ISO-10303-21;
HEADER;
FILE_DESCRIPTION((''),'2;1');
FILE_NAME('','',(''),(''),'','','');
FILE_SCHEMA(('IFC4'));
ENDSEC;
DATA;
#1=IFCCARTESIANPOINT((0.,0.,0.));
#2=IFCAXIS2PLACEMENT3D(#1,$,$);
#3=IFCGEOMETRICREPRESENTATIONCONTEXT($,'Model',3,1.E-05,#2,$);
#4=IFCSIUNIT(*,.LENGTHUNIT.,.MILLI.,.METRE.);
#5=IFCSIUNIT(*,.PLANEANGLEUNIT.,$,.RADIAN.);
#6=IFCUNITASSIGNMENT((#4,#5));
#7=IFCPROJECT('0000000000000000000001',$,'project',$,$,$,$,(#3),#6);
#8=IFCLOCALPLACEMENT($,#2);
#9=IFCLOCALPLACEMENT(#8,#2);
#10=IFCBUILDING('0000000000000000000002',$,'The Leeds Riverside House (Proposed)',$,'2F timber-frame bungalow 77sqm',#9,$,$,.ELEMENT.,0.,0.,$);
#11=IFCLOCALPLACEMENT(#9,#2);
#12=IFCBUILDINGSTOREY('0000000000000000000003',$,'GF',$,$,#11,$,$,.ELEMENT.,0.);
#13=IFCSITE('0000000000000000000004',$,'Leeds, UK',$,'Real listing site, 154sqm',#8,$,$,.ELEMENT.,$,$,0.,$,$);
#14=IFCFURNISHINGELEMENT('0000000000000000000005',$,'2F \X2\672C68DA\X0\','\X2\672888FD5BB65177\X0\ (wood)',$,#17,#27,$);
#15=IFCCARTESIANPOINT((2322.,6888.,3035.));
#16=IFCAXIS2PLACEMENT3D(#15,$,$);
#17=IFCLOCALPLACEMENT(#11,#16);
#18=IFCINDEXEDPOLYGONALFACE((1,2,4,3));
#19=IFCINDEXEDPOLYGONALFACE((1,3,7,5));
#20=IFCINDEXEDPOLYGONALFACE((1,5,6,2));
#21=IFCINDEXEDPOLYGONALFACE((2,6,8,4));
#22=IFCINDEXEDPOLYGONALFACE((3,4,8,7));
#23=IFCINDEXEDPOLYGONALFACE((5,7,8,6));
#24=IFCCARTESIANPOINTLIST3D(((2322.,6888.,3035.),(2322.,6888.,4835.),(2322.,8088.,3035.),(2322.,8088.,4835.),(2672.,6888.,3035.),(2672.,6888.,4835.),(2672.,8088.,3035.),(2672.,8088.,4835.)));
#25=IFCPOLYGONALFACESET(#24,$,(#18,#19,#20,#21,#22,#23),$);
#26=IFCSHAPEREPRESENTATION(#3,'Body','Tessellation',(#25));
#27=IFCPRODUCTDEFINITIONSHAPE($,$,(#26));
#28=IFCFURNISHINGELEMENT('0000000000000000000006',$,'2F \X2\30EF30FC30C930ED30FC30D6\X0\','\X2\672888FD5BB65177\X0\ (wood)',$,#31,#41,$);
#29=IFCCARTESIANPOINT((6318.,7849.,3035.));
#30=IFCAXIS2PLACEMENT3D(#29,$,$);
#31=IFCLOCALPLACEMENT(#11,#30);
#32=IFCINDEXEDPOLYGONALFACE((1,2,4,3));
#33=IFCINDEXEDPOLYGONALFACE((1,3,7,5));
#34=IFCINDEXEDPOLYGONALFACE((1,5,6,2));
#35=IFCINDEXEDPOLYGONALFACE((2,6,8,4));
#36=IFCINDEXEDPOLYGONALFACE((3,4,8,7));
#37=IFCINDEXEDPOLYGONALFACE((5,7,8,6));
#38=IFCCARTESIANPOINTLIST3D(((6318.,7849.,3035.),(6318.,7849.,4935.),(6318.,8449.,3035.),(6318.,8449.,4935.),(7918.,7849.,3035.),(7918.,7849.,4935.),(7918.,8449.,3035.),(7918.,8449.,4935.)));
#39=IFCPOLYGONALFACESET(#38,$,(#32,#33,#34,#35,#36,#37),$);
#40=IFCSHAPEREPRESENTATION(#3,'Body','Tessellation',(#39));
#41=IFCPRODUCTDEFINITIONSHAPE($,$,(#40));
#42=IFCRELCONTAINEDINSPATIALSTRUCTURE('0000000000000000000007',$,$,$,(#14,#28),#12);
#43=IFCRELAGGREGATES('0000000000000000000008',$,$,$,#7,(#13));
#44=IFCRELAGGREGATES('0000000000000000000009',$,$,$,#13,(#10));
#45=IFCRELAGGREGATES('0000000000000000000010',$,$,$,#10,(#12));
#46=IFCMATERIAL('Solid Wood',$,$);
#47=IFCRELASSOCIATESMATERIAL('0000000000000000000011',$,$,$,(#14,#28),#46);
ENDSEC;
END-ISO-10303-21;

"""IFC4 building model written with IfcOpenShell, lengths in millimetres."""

from ifc_helpers import new_model, si_unit, frame, frame_2d, origin, place, context, project, spatial, rectangle, extrude, material, element, save


model = new_model("IFC4")

# Units and contexts
model_context = context("Model", 3, precision=1e-05, world=origin())
ifc_project = project(units=[si_unit("LENGTHUNIT", "METRE", prefix="MILLI"), si_unit("PLANEANGLEUNIT", "RADIAN")], contexts=[model_context])

# Site, building, storey
site_placement = place(None, origin())
site = spatial("IfcSite", under=ifc_project, at=site_placement, Name="Leeds, UK", ObjectType="Real listing site, 154sqm", CompositionType="ELEMENT", RefElevation=0.0)
building_placement = place(site_placement, origin())
building = spatial("IfcBuilding", under=site, at=building_placement, Name="The Leeds Riverside House (Proposed)", ObjectType="2F timber-frame bungalow 77sqm", CompositionType="ELEMENT", ElevationOfRefHeight=0.0, ElevationOfTerrain=0.0)
storey_placement = place(building_placement, origin())
storey = spatial("IfcBuildingStorey", under=building, at=storey_placement, Name="GF", CompositionType="ELEMENT", Elevation=0.0)

# Shared definitions
ifc_material_1 = material(Name="Solid Wood")

# Furnishing elements
furnishing_1_placement = place(storey_placement, frame((2322.0, 6888.0, 3035.0)))
element("IfcFurnishingElement", 1, at=furnishing_1_placement, inside=storey, material=ifc_material_1, Name="2F 本棚", Description="木製家具 (wood)", context=model_context, shape_type="SweptSolid", body=[
    extrude(rectangle(XDim=350.0, YDim=1200.0, at=frame_2d((175.0, 600.0))), frame((2322.0, 6888.0, 3035.0)), (0.0, 0.0, 1.0), 1800.0),
])
furnishing_2_placement = place(storey_placement, frame((6318.0, 7849.0, 3035.0)))
element("IfcFurnishingElement", 2, at=furnishing_2_placement, inside=storey, material=ifc_material_1, Name="2F ワードローブ", Description="木製家具 (wood)", context=model_context, shape_type="SweptSolid", body=[
    extrude(rectangle(XDim=1600.0, YDim=600.0, at=frame_2d((800.0, 300.0))), frame((6318.0, 7849.0, 3035.0)), (0.0, 0.0, 1.0), 1900.0),
])

save(model, "model.ifc")
